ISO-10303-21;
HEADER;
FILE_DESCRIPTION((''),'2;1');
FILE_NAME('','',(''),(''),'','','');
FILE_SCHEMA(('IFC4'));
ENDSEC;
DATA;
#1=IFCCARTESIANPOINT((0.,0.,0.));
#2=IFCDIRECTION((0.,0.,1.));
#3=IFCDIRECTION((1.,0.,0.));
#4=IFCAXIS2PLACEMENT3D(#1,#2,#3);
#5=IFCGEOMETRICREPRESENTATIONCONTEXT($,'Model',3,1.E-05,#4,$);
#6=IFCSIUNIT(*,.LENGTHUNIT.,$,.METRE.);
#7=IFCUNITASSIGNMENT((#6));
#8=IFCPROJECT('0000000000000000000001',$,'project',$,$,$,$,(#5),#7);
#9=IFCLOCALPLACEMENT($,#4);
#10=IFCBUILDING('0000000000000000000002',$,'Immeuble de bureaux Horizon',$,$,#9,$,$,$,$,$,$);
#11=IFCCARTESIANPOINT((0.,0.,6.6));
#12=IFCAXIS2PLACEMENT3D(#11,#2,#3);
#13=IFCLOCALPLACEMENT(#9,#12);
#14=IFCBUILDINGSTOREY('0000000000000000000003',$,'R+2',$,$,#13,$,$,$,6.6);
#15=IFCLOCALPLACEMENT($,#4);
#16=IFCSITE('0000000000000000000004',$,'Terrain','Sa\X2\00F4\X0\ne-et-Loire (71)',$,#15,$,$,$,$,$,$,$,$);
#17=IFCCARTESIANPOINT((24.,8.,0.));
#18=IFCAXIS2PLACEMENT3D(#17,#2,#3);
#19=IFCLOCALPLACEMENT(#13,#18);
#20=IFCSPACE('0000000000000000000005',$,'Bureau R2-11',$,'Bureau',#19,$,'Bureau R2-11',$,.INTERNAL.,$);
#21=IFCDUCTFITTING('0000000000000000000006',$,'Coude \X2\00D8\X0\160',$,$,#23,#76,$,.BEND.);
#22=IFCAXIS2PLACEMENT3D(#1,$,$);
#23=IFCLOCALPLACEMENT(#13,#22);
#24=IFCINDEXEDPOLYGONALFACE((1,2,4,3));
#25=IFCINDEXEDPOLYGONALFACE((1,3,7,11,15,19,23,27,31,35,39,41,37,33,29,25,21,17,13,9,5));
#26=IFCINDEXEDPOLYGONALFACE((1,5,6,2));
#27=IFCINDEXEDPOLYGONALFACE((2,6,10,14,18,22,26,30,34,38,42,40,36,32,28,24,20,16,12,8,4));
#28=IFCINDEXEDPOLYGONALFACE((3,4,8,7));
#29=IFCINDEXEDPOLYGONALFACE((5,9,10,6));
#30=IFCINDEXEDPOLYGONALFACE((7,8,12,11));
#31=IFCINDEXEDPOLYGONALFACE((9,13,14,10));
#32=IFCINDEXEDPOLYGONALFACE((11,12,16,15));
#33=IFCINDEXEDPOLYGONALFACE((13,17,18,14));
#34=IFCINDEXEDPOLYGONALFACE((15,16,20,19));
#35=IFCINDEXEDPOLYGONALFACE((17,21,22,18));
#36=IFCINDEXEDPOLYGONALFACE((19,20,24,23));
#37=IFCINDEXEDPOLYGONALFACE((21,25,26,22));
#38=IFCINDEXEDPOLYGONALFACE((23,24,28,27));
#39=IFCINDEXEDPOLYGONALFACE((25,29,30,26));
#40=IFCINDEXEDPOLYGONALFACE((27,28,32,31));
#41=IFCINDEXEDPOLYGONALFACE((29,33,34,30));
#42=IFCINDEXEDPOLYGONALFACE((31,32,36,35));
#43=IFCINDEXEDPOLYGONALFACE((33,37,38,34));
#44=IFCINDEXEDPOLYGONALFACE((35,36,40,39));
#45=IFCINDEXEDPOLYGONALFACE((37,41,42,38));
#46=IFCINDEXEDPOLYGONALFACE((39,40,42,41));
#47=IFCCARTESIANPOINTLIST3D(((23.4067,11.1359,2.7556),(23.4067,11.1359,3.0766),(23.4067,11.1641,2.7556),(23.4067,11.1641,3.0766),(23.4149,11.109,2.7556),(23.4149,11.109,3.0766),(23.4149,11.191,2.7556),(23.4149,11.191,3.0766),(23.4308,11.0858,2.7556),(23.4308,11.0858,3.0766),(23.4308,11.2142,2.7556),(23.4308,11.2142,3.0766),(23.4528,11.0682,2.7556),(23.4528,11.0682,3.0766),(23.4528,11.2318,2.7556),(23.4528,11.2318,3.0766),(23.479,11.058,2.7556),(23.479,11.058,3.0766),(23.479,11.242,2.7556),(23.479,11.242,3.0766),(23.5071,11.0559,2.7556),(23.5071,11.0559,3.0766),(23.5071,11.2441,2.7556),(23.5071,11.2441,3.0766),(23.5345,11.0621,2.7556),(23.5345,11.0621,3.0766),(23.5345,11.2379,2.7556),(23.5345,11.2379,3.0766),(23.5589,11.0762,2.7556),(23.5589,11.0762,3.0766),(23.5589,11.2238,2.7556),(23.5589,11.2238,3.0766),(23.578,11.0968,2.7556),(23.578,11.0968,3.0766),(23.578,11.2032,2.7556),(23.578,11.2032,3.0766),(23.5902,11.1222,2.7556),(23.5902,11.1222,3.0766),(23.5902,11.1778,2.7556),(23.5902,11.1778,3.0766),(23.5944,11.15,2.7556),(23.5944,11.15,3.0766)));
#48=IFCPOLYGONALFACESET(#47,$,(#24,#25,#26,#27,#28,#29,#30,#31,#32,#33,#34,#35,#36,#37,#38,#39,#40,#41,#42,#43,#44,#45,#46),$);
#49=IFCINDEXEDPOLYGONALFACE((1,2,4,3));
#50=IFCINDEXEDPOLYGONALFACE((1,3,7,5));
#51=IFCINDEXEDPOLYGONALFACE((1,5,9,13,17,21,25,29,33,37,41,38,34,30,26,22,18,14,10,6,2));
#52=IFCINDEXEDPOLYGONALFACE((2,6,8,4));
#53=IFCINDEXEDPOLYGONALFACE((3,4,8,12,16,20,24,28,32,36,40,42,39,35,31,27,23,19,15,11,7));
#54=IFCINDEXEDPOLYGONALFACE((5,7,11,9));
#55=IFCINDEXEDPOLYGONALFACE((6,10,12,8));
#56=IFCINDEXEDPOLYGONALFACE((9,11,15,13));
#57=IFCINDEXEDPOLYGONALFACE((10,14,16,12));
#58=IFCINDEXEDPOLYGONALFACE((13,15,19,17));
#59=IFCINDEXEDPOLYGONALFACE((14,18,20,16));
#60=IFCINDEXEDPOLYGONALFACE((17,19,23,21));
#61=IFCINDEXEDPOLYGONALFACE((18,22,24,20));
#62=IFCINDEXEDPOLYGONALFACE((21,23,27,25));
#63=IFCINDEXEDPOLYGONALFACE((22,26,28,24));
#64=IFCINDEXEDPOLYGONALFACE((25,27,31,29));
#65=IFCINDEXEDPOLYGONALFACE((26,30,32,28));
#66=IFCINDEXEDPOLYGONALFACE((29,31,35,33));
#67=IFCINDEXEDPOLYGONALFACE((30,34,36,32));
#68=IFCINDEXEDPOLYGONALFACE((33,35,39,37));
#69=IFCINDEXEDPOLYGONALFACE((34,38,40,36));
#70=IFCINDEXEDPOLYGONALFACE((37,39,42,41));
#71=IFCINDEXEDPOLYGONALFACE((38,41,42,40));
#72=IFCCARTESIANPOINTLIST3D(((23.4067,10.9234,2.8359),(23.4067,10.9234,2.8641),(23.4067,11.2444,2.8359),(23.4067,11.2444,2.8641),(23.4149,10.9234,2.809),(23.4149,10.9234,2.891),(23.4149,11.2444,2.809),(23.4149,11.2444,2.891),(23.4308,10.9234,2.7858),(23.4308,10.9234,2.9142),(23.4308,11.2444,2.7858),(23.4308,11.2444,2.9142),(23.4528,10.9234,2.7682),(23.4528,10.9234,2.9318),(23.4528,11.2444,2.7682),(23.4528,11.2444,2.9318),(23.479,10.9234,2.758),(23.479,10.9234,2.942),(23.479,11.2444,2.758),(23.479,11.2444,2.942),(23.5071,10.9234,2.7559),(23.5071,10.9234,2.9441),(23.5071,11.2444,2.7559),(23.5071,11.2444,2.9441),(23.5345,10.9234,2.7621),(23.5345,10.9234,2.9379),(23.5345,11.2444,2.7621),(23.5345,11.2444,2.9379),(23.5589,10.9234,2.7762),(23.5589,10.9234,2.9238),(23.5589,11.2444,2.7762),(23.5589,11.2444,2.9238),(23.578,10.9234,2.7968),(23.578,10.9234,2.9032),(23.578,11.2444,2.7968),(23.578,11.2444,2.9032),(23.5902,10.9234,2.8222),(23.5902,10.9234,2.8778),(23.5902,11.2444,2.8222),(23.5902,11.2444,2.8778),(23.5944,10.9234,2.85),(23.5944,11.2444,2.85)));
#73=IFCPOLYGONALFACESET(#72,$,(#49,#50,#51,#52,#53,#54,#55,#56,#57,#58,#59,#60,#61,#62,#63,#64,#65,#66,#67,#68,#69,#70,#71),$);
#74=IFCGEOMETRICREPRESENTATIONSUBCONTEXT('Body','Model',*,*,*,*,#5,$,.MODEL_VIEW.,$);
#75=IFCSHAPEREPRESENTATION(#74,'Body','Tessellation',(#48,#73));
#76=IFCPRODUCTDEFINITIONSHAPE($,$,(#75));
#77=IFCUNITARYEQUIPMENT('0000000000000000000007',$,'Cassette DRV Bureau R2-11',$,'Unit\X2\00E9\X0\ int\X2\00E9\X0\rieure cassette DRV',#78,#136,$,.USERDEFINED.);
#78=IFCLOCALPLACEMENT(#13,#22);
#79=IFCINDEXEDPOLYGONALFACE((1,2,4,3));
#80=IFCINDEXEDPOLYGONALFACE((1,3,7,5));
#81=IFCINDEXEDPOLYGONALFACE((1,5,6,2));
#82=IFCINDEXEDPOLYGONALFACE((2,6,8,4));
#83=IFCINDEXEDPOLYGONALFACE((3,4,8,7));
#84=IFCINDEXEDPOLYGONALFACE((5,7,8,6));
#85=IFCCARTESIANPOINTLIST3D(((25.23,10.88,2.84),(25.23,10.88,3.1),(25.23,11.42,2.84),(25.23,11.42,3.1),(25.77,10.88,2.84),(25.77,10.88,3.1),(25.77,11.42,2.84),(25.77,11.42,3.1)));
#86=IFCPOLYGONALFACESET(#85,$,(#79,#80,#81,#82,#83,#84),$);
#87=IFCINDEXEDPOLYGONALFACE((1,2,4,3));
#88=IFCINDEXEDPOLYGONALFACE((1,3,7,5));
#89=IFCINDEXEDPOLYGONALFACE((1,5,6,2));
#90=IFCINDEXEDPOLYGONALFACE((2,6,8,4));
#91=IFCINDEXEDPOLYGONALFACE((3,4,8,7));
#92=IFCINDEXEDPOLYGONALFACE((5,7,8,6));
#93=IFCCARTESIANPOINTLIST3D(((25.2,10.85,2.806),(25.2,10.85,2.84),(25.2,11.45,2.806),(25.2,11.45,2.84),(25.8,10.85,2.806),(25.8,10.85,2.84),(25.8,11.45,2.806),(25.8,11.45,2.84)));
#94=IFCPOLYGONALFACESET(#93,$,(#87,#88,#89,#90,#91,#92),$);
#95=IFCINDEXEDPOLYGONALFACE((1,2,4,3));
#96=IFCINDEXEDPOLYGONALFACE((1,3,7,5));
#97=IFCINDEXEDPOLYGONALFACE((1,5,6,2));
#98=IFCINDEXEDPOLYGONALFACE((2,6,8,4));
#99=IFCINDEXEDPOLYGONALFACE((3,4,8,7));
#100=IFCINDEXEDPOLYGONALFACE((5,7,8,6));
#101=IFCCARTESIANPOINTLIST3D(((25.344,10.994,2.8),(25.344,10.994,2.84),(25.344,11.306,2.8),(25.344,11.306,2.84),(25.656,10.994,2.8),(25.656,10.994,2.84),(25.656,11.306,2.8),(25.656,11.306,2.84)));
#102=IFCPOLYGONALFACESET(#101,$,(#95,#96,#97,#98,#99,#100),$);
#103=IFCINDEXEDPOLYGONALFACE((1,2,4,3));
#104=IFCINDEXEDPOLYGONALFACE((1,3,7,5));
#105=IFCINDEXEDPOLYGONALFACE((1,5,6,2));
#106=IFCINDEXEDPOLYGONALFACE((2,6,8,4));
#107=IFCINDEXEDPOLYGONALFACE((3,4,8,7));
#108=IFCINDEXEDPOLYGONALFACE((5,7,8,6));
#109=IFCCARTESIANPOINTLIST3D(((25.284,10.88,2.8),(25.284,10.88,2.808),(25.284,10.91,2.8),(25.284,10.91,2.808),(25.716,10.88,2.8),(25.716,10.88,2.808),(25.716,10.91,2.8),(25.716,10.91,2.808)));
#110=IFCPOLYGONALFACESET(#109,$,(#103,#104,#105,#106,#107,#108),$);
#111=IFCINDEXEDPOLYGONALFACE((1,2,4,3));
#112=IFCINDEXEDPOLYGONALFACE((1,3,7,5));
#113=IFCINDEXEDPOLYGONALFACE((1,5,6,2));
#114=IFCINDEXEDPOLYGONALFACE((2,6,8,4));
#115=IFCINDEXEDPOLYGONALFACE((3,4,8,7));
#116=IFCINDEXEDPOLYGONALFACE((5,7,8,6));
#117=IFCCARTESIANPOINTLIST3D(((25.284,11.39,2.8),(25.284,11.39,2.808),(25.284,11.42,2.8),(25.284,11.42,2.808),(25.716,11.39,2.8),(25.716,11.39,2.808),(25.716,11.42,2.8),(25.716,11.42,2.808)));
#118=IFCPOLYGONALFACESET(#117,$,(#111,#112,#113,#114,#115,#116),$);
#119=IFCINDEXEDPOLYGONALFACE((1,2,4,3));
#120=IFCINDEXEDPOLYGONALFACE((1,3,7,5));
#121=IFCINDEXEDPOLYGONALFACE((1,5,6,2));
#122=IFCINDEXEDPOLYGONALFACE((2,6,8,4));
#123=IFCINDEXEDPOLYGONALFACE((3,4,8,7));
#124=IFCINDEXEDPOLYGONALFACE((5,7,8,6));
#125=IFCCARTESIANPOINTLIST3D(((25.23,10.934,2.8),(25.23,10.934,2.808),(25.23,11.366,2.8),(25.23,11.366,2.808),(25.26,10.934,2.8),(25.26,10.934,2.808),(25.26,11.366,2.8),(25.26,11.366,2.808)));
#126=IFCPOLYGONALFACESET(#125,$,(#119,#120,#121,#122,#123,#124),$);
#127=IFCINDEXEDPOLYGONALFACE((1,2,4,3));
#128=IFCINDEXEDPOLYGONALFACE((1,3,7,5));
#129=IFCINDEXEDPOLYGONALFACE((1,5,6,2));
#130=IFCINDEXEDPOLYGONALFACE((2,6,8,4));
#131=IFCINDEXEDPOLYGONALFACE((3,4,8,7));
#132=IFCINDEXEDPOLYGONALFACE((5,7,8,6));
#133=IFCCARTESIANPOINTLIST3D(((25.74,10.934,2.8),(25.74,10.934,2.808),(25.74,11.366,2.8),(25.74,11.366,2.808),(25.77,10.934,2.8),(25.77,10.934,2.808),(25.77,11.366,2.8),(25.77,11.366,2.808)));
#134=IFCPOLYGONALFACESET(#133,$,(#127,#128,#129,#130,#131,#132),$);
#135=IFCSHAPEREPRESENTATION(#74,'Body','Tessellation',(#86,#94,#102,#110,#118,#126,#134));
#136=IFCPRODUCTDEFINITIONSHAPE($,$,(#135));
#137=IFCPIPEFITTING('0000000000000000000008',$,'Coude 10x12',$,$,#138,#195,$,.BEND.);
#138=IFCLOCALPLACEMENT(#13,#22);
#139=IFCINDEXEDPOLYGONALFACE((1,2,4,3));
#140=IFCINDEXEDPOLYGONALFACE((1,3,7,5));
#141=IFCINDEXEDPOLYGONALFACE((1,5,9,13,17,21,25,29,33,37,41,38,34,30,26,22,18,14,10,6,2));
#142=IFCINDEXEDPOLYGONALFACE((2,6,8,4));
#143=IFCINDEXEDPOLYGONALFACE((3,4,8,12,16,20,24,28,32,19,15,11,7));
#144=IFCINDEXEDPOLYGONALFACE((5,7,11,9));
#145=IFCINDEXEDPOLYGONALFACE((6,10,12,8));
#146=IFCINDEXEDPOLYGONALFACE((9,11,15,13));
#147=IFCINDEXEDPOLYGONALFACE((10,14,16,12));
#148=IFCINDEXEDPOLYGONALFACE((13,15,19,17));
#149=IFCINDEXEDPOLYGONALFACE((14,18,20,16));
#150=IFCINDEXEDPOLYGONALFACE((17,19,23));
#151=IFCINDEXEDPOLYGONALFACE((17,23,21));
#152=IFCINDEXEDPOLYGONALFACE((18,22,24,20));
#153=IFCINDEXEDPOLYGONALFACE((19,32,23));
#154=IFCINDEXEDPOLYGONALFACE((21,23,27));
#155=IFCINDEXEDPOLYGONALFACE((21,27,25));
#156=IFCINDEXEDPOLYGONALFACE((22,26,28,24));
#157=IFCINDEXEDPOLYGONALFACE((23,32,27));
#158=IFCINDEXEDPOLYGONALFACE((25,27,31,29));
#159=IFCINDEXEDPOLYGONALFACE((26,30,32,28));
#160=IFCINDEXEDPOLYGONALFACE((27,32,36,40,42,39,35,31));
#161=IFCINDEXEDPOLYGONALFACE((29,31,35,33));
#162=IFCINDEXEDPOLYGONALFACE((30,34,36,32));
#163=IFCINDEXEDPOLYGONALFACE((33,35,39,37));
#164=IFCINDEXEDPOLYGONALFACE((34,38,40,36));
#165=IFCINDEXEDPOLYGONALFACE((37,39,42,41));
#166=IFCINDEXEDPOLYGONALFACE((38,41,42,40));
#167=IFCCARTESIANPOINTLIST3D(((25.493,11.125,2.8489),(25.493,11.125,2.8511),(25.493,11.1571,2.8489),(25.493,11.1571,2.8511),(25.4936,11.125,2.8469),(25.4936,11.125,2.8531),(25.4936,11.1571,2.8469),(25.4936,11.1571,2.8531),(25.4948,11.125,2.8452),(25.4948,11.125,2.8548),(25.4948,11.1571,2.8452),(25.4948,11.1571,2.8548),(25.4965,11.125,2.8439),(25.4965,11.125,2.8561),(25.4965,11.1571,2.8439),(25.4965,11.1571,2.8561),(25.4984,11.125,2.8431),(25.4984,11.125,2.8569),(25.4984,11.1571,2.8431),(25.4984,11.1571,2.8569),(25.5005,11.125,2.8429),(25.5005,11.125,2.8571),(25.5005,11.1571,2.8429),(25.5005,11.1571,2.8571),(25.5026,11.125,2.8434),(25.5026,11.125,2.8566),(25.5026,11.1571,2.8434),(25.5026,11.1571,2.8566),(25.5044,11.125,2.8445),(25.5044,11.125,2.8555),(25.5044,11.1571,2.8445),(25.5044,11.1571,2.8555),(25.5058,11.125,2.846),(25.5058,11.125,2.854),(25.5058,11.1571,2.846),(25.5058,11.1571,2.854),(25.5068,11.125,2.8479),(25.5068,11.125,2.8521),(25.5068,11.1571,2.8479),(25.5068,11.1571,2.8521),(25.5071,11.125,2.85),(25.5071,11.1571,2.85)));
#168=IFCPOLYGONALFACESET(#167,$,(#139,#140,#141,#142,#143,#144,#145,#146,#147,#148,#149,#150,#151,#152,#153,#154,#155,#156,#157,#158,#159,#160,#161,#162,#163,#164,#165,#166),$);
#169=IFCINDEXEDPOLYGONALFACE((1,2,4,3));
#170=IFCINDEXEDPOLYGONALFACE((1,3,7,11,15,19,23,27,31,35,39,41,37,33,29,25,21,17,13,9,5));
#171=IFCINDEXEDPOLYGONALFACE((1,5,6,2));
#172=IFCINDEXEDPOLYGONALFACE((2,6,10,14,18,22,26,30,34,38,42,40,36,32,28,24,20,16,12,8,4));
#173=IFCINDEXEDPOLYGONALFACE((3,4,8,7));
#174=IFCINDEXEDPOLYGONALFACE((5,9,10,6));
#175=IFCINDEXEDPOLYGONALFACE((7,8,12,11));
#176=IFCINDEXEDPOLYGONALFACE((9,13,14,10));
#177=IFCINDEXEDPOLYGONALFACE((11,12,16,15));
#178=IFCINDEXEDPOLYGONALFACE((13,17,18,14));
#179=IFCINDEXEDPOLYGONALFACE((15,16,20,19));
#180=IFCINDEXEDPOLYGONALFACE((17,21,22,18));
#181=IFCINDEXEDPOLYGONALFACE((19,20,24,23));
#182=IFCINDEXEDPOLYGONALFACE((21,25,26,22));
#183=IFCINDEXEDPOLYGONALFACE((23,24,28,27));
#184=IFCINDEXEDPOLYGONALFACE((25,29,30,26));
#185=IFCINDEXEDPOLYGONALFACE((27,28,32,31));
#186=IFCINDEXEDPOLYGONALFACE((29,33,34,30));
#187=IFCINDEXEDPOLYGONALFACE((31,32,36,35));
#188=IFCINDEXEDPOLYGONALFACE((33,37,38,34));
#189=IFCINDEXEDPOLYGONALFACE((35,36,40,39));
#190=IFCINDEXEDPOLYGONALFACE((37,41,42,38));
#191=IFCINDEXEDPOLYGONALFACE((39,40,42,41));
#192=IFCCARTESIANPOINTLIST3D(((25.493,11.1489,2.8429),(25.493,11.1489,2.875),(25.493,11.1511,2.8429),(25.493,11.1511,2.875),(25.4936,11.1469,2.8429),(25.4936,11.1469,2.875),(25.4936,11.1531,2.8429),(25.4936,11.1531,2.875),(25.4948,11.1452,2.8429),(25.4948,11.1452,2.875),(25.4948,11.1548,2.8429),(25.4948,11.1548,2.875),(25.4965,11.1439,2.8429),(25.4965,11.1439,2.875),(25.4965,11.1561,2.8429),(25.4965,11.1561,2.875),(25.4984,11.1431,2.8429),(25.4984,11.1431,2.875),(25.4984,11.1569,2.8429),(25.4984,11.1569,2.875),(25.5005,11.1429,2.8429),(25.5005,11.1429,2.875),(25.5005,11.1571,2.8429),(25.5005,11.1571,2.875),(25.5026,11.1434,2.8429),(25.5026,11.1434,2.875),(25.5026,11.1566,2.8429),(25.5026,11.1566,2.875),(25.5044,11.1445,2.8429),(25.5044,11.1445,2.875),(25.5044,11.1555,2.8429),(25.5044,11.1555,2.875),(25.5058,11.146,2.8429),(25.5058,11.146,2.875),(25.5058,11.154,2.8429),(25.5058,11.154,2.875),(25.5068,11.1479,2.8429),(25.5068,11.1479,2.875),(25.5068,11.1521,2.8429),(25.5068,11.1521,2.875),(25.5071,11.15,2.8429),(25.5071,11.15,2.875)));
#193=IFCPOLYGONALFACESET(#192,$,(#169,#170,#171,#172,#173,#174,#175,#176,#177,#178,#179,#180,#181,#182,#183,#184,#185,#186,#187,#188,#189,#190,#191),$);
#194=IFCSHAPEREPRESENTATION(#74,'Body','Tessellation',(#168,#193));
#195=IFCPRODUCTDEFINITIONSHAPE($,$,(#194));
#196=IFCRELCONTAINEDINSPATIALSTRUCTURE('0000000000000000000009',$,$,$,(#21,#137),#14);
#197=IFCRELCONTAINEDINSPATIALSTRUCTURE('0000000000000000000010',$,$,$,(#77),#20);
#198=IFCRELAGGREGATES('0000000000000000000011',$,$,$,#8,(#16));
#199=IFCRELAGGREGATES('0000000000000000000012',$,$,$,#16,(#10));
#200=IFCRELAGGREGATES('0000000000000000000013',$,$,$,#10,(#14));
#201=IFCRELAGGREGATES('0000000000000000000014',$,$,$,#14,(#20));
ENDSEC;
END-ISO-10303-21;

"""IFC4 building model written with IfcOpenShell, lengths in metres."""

from ifc_helpers import new_model, si_unit, frame, frame_2d, origin_with_axes, place, context, subcontext, project, spatial, rectangle, circle, extrude, element, save


model = new_model("IFC4")

# Units and contexts
model_context = context("Model", 3, precision=1e-05, world=origin_with_axes())
body_context = subcontext(model_context, "Body", "Model", "MODEL_VIEW")
ifc_project = project(units=[si_unit("LENGTHUNIT", "METRE")], contexts=[model_context])

# Site, building, storey
site_placement = place(None, origin_with_axes())
site = spatial("IfcSite", under=ifc_project, at=site_placement, Name="Terrain", Description="Saône-et-Loire (71)")
building_placement = place(None, origin_with_axes())
building = spatial("IfcBuilding", under=site, at=building_placement, Name="Immeuble de bureaux Horizon")
storey_placement = place(building_placement, frame((0.0, 0.0, 6.6), z_axis=(0.0, 0.0, 1.0), x_axis=(1.0, 0.0, 0.0)))
storey = spatial("IfcBuildingStorey", under=building, at=storey_placement, Name="R+2", Elevation=6.6)

# Duct fitting
duct_fitting_1_placement = place(storey_placement, frame((23.5, 11.15, 2.85), z_axis=(0.0, 0.0, 1.0), x_axis=(1.0, 0.0, 0.0)))
element("IfcDuctFitting", 1, at=duct_fitting_1_placement, inside=storey, Name="Coude Ø160", PredefinedType="BEND", context=body_context, shape_type="SweptSolid", body=[
    extrude(circle(Radius=0.0944), frame((0.0, 0.0, -0.0944), z_axis=(0.0, 0.0, 1.0), x_axis=(1.0, 0.0, 0.0)), (0.0, 0.0, 1.0), 0.321),
    extrude(circle(Radius=0.0944), frame((0.0, 0.0944, 0.0), z_axis=(0.0, -1.0, 0.0), x_axis=(1.0, 0.0, 0.0)), (0.0, 0.0, 1.0), 0.321),
])

# Shared definitions
space_1_placement = place(storey_placement, frame((24.0, 8.0, 0.0), z_axis=(0.0, 0.0, 1.0), x_axis=(1.0, 0.0, 0.0)))
space_1 = spatial("IfcSpace", under=storey, at=space_1_placement, Name="Bureau R2-11", ObjectType="Bureau", LongName="Bureau R2-11", PredefinedType="INTERNAL")

# Unitary equipment
unitary_equipment_1_placement = place(space_1_placement, frame((1.2, 2.85, 2.8), z_axis=(0.0, 0.0, 1.0), x_axis=(1.0, 0.0, 0.0)))
element("IfcUnitaryEquipment", 2, at=unitary_equipment_1_placement, inside=space_1, Name="Cassette DRV Bureau R2-11", ObjectType="Unité intérieure cassette DRV", PredefinedType="USERDEFINED", context=body_context, shape_type="SweptSolid", body=[
    extrude(rectangle(XDim=0.54, YDim=0.54, at=frame_2d((0.27, 0.27))), frame((0.03, 0.03, 0.04), z_axis=(0.0, 0.0, 1.0), x_axis=(1.0, 0.0, 0.0)), (0.0, 0.0, 1.0), 0.26),
    extrude(rectangle(XDim=0.6, YDim=0.6, at=frame_2d((0.3, 0.3))), frame((0.0, 0.0, 0.006), z_axis=(0.0, 0.0, 1.0), x_axis=(1.0, 0.0, 0.0)), (0.0, 0.0, 1.0), 0.034),
    extrude(rectangle(XDim=0.312, YDim=0.312, at=frame_2d((0.156, 0.156))), frame((0.144, 0.144, 0.0), z_axis=(0.0, 0.0, 1.0), x_axis=(1.0, 0.0, 0.0)), (0.0, 0.0, 1.0), 0.04),
    extrude(rectangle(XDim=0.432, YDim=0.03, at=frame_2d((0.216, 0.015))), frame((0.084, 0.03, 0.0), z_axis=(0.0, 0.0, 1.0), x_axis=(1.0, 0.0, 0.0)), (0.0, 0.0, 1.0), 0.008),
    extrude(rectangle(XDim=0.432, YDim=0.03, at=frame_2d((0.216, 0.015))), frame((0.084, 0.54, 0.0), z_axis=(0.0, 0.0, 1.0), x_axis=(1.0, 0.0, 0.0)), (0.0, 0.0, 1.0), 0.008),
    extrude(rectangle(XDim=0.03, YDim=0.432, at=frame_2d((0.015, 0.216))), frame((0.03, 0.084, 0.0), z_axis=(0.0, 0.0, 1.0), x_axis=(1.0, 0.0, 0.0)), (0.0, 0.0, 1.0), 0.008),
    extrude(rectangle(XDim=0.03, YDim=0.432, at=frame_2d((0.015, 0.216))), frame((0.54, 0.084, 0.0), z_axis=(0.0, 0.0, 1.0), x_axis=(1.0, 0.0, 0.0)), (0.0, 0.0, 1.0), 0.008),
])

# Pipe fitting
pipe_fitting_1_placement = place(storey_placement, frame((25.5, 11.15, 2.85), z_axis=(0.0, 0.0, 1.0), x_axis=(1.0, 0.0, 0.0)))
element("IfcPipeFitting", 3, at=pipe_fitting_1_placement, inside=storey, Name="Coude 10x12", PredefinedType="BEND", context=body_context, shape_type="SweptSolid", body=[
    extrude(circle(Radius=0.0071), frame((0.0, 0.0071, 0.0), z_axis=(0.0, -1.0, 0.0), x_axis=(1.0, 0.0, 0.0)), (0.0, 0.0, 1.0), 0.0321),
    extrude(circle(Radius=0.0071), frame((0.0, 0.0, -0.0071), z_axis=(0.0, 0.0, 1.0), x_axis=(1.0, 0.0, 0.0)), (0.0, 0.0, 1.0), 0.0321),
])

save(model, "model.ifc")
